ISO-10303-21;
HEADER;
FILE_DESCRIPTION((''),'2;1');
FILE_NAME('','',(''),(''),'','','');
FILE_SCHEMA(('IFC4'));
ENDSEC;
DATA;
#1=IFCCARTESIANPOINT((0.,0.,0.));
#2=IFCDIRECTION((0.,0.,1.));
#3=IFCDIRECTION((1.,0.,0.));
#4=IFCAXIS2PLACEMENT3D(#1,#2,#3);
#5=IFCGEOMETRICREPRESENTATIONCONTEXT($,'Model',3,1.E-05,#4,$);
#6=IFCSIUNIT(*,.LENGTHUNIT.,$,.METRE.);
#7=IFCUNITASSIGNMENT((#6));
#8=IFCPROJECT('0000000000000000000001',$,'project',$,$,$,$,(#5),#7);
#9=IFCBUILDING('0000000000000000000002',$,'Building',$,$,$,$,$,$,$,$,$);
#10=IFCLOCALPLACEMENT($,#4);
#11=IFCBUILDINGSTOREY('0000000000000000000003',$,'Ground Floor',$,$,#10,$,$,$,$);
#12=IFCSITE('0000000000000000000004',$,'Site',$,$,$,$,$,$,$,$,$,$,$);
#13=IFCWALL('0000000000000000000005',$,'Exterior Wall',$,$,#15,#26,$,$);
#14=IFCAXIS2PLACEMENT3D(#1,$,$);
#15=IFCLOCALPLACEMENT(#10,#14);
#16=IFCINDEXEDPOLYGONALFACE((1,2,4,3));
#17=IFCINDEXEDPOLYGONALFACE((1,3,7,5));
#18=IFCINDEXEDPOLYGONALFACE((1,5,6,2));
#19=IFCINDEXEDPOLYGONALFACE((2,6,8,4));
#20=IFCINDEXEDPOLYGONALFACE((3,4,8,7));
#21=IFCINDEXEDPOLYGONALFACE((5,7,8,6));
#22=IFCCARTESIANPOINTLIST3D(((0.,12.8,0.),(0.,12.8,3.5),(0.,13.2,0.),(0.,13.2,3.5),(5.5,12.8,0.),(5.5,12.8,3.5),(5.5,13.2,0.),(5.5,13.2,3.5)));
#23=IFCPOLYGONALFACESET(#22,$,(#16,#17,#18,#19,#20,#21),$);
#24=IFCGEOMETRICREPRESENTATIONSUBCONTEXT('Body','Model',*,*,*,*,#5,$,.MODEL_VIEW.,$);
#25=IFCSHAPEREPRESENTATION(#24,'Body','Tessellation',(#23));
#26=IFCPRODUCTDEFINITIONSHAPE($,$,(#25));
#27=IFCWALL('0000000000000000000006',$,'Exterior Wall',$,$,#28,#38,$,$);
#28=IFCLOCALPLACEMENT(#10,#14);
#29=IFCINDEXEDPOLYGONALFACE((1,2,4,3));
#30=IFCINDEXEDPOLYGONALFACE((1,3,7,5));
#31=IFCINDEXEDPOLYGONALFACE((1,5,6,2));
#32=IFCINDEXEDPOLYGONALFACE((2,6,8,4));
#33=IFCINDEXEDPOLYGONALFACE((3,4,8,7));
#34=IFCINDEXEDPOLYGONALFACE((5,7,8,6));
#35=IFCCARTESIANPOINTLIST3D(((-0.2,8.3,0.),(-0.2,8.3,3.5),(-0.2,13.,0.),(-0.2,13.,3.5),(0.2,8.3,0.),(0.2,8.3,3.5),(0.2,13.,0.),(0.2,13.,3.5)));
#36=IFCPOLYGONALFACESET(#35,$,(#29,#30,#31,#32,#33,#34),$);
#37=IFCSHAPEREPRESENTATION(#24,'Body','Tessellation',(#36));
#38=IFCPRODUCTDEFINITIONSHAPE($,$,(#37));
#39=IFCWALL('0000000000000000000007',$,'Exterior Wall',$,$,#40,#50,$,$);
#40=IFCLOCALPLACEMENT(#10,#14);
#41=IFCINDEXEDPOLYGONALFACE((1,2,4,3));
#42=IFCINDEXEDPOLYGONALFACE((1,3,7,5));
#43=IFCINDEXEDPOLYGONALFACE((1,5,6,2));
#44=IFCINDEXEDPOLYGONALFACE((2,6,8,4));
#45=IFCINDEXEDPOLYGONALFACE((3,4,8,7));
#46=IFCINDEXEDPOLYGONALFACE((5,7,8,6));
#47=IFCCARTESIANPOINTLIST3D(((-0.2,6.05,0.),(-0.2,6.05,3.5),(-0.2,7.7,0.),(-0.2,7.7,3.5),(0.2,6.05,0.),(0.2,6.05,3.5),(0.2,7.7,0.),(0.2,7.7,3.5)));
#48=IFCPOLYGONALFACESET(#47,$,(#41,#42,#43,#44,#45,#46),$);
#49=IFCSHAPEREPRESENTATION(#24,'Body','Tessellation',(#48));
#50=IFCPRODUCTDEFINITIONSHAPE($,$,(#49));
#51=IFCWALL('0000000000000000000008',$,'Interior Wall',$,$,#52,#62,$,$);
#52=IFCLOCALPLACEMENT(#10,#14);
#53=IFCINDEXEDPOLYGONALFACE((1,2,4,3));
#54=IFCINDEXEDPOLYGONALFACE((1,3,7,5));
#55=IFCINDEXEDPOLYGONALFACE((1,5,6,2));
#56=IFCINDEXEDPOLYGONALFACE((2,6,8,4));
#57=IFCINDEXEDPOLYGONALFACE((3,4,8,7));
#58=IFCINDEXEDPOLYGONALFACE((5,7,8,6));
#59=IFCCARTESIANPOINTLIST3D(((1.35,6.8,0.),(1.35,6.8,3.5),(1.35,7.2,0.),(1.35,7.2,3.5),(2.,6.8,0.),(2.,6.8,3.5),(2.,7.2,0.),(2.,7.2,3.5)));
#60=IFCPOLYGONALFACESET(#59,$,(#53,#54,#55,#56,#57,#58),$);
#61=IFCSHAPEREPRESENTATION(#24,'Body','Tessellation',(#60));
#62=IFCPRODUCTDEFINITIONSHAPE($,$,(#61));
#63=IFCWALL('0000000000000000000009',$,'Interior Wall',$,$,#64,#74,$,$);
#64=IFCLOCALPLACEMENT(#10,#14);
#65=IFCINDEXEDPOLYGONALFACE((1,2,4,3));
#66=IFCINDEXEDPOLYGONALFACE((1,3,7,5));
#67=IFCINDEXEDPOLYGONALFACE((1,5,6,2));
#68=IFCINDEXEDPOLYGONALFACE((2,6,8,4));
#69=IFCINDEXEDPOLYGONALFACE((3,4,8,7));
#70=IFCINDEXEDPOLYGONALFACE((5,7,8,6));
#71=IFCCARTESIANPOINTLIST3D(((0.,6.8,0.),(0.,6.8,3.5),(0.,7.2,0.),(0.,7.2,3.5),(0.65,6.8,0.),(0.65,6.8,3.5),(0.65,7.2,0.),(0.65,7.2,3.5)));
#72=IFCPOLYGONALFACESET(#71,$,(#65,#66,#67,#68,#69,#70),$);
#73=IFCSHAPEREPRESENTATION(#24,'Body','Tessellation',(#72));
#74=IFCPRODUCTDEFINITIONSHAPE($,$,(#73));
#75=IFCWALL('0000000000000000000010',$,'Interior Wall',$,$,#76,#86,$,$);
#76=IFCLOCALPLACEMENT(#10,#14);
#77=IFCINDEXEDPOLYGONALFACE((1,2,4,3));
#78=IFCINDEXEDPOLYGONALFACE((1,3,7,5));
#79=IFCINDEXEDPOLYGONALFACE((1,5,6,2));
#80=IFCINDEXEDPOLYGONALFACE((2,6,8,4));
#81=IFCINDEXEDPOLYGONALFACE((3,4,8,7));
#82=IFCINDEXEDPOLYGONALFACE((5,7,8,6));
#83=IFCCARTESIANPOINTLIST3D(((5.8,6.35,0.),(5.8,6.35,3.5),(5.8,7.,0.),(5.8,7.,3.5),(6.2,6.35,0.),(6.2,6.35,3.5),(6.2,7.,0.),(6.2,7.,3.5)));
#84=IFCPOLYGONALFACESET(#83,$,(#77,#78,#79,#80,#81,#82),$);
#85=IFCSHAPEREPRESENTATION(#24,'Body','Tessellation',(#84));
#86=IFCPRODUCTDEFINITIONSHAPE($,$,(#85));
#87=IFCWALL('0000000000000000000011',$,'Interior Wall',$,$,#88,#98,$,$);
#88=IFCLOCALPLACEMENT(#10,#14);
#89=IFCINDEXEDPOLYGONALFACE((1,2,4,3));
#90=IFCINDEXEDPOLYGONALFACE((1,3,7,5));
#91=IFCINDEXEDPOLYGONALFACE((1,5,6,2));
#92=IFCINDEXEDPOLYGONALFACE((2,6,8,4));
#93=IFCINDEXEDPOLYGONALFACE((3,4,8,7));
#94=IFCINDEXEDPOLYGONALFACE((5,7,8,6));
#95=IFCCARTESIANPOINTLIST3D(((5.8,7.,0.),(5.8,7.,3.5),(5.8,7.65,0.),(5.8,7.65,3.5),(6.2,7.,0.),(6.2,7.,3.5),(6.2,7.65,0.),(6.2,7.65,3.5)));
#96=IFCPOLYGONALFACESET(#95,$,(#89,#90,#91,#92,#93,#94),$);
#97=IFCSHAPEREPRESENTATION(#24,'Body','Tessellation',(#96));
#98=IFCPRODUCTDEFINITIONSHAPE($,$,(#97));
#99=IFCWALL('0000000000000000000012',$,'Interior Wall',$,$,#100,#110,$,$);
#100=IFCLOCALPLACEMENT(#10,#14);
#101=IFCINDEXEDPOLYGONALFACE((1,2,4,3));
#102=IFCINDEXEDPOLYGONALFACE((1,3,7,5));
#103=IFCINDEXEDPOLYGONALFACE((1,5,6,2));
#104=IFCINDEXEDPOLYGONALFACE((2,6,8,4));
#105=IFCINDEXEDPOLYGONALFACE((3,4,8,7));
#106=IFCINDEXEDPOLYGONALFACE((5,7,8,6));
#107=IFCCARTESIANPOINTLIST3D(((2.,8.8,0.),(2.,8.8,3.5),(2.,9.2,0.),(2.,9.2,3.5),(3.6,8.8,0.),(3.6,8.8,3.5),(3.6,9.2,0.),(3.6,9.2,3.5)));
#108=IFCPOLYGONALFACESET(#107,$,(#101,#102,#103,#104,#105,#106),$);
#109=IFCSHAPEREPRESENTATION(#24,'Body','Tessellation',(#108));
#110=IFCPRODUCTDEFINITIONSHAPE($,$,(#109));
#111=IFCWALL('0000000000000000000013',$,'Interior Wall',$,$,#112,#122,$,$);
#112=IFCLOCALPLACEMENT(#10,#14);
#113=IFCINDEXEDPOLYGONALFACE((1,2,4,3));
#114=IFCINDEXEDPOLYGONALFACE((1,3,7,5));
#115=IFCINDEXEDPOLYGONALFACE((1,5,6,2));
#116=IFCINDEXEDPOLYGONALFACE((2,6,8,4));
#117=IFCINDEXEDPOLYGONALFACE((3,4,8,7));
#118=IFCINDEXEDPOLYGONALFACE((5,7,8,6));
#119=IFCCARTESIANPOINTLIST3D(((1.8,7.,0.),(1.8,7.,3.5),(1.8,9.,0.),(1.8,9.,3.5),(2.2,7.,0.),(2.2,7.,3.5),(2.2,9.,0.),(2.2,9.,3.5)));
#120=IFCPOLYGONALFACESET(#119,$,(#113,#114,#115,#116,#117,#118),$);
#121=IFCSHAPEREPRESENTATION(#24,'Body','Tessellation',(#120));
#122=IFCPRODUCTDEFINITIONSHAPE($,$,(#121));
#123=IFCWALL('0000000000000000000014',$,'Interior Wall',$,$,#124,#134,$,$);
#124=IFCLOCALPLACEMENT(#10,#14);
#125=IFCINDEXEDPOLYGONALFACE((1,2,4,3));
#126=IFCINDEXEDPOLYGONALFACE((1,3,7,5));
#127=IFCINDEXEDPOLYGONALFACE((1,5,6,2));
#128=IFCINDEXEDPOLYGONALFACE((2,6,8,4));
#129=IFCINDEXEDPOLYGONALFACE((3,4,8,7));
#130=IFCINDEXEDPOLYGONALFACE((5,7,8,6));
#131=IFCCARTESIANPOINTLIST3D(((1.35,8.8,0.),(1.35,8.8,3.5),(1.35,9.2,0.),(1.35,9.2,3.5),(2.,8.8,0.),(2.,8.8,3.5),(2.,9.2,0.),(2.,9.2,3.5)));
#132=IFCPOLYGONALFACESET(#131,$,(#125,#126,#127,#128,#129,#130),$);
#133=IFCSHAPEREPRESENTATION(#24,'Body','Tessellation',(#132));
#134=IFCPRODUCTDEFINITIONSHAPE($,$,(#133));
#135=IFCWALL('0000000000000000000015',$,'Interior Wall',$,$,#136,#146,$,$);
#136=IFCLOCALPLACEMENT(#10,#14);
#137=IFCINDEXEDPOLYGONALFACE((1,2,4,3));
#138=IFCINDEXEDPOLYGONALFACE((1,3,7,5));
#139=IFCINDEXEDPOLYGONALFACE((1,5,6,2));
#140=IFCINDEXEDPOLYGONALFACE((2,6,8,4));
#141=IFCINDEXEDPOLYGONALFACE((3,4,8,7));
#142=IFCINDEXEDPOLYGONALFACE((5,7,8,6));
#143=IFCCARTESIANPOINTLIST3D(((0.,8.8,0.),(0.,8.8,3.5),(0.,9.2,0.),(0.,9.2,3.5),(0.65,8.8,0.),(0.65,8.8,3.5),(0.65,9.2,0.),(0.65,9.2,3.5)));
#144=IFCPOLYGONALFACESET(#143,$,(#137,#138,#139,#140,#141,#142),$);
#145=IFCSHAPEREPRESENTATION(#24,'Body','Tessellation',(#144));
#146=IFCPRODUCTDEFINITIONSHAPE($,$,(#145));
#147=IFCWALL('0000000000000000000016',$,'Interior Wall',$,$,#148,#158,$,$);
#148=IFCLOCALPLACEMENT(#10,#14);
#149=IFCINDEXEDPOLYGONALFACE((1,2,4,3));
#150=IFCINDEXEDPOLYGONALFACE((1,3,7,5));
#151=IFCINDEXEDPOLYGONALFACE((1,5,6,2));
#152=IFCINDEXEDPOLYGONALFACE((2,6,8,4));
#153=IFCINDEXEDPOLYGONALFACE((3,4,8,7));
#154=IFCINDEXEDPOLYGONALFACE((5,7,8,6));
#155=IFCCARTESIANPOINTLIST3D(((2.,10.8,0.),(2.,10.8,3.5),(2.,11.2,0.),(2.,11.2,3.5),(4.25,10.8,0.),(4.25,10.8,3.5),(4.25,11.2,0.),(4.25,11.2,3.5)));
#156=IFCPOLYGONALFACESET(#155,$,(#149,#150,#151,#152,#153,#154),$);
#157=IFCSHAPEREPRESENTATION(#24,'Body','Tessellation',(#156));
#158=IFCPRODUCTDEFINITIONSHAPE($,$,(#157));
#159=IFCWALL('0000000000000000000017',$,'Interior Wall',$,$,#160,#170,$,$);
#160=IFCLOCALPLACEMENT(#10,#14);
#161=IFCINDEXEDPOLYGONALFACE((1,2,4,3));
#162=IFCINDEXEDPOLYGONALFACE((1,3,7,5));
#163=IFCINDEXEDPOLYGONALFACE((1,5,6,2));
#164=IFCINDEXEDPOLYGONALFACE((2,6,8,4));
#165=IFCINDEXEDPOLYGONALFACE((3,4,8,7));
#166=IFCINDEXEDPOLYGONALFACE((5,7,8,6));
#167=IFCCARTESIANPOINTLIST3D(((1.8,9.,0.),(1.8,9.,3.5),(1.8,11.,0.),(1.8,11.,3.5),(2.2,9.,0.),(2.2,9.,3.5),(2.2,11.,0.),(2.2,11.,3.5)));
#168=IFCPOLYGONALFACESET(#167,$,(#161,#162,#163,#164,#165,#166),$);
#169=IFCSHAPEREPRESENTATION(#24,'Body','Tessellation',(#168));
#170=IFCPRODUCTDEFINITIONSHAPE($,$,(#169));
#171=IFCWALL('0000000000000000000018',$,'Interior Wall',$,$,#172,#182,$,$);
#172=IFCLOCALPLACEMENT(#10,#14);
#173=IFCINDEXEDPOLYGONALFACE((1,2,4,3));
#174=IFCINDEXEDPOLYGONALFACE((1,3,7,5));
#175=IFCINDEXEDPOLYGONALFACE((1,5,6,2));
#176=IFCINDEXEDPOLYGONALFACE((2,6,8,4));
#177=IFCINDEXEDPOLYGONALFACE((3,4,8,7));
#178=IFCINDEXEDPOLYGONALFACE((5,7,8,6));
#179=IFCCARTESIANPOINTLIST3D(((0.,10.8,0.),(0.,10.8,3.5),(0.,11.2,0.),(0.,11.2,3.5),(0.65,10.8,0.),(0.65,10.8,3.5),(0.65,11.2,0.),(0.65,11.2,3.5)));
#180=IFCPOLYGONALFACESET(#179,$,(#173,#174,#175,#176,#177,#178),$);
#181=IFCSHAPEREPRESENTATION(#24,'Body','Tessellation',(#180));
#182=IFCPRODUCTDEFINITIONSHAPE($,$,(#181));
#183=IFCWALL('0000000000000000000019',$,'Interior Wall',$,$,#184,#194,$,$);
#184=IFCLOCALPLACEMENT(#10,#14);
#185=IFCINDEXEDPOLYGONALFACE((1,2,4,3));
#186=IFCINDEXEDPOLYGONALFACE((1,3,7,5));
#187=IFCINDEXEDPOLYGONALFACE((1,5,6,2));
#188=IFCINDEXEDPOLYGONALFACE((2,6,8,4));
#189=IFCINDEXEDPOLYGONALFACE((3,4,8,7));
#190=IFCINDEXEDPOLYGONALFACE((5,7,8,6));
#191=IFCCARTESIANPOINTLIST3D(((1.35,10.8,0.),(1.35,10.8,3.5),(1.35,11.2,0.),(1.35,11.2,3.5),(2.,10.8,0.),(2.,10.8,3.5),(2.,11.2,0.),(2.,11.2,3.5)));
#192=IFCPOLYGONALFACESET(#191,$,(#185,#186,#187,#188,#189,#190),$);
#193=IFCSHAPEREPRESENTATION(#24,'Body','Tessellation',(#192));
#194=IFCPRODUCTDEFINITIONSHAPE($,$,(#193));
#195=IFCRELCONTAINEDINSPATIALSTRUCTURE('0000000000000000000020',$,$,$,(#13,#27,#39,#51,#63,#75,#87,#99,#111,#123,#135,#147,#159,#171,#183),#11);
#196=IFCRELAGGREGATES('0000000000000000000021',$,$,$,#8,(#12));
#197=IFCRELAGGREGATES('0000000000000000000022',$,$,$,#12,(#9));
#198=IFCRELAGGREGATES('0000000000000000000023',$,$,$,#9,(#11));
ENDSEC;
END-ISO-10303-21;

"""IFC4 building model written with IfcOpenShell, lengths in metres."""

from ifc_helpers import new_model, si_unit, frame, origin_with_axes, place, context, subcontext, project, spatial, indexed_curve, outline, extrude, element, save


model = new_model("IFC4")

# Units and contexts
model_context = context("Model", 3, precision=1e-05, world=origin_with_axes())
body_context = subcontext(model_context, "Body", "Model", "MODEL_VIEW")
ifc_project = project(units=[si_unit("LENGTHUNIT", "METRE")], contexts=[model_context])

# Site, building, storey
site = spatial("IfcSite", under=ifc_project, Name="Site")
building = spatial("IfcBuilding", under=site, Name="Building")
storey_placement = place(None, origin_with_axes())
storey = spatial("IfcBuildingStorey", under=building, at=storey_placement, Name="Ground Floor")

# Walls
wall_1_placement = place(storey_placement, frame((5.5, 13.0, 0.0), z_axis=(0.0, 0.0, 1.0), x_axis=(-1.0, 0.0, 0.0)))
element("IfcWall", 1, at=wall_1_placement, inside=storey, Name="Exterior Wall", context=body_context, shape_type="SweptSolid", body=[
    extrude(outline(indexed_curve([(0.0, 0.0), (0.0, 0.4), (5.5, 0.4), (5.5, 0.0), (0.0, 0.0)], self_intersect=False)), frame((0.0, -0.2, 0.0), z_axis=(0.0, 0.0, 1.0), x_axis=(1.0, 0.0, 0.0)), (0.0, 0.0, 1.0), 3.5),
])
wall_2_placement = place(storey_placement, frame((0.0, 13.0, 0.0), z_axis=(0.0, 0.0, 1.0), x_axis=(0.0, -1.0, 0.0)))
element("IfcWall", 2, at=wall_2_placement, inside=storey, Name="Exterior Wall", context=body_context, shape_type="SweptSolid", body=[
    extrude(outline(indexed_curve([(0.0, 0.0), (0.0, 0.4), (4.7, 0.4), (4.7, 0.0), (0.0, 0.0)], self_intersect=False)), frame((0.0, -0.2, 0.0), z_axis=(0.0, 0.0, 1.0), x_axis=(1.0, 0.0, 0.0)), (0.0, 0.0, 1.0), 3.5),
])
wall_3_placement = place(storey_placement, frame((0.0, 7.7, 0.0), z_axis=(0.0, 0.0, 1.0), x_axis=(0.0, -1.0, 0.0)))
element("IfcWall", 3, at=wall_3_placement, inside=storey, Name="Exterior Wall", context=body_context, shape_type="SweptSolid", body=[
    extrude(outline(indexed_curve([(0.0, 0.0), (0.0, 0.4), (1.65, 0.4), (1.65, 0.0), (0.0, 0.0)], self_intersect=False)), frame((0.0, -0.2, 0.0), z_axis=(0.0, 0.0, 1.0), x_axis=(1.0, 0.0, 0.0)), (0.0, 0.0, 1.0), 3.5),
])
for number, where, z_axis, x_axis, name in (
    (4, (2.0, 7.0, 0.0), (0.0, 0.0, 1.0), (-1.0, 0.0, 0.0), "Interior Wall"),
    (5, (0.65, 7.0, 0.0), (0.0, 0.0, 1.0), (-1.0, 0.0, 0.0), "Interior Wall"),
):
    element("IfcWall", number, at=place(storey_placement, frame(where, z_axis=z_axis, x_axis=x_axis)), inside=storey, Name=name, context=body_context, shape_type="SweptSolid", body=[
        extrude(outline(indexed_curve([(0.0, 0.0), (0.0, 0.4), (0.65, 0.4), (0.65, 0.0), (0.0, 0.0)], self_intersect=False)), frame((0.0, -0.2, 0.0), z_axis=(0.0, 0.0, 1.0), x_axis=(1.0, 0.0, 0.0)), (0.0, 0.0, 1.0), 3.5),
    ])
for number, where, z_axis, x_axis, name in (
    (6, (6.0, 6.35, 0.0), (0.0, 0.0, 1.0), (0.0, 1.0, 0.0), "Interior Wall"),
    (7, (6.0, 7.0, 0.0), (0.0, 0.0, 1.0), (0.0, 1.0, 0.0), "Interior Wall"),
):
    element("IfcWall", number, at=place(storey_placement, frame(where, z_axis=z_axis, x_axis=x_axis)), inside=storey, Name=name, context=body_context, shape_type="SweptSolid", body=[
        extrude(outline(indexed_curve([(0.0, 0.0), (0.0, 0.4), (0.65, 0.4), (0.65, 0.0), (0.0, 0.0)], self_intersect=False)), frame((0.0, -0.2, 0.0), z_axis=(0.0, 0.0, 1.0), x_axis=(1.0, 0.0, 0.0)), (0.0, 0.0, 1.0), 3.5),
    ])
wall_4_placement = place(storey_placement, frame((3.6, 9.0, 0.0), z_axis=(0.0, 0.0, 1.0), x_axis=(-1.0, 0.0, 0.0)))
element("IfcWall", 8, at=wall_4_placement, inside=storey, Name="Interior Wall", context=body_context, shape_type="SweptSolid", body=[
    extrude(outline(indexed_curve([(0.0, 0.0), (0.0, 0.4), (1.6, 0.4), (1.6, 0.0), (0.0, 0.0)], self_intersect=False)), frame((0.0, -0.2, 0.0), z_axis=(0.0, 0.0, 1.0), x_axis=(1.0, 0.0, 0.0)), (0.0, 0.0, 1.0), 3.5),
])
wall_5_placement = place(storey_placement, frame((2.0, 9.0, 0.0), z_axis=(0.0, 0.0, 1.0), x_axis=(0.0, -1.0, 0.0)))
element("IfcWall", 9, at=wall_5_placement, inside=storey, Name="Interior Wall", context=body_context, shape_type="SweptSolid", body=[
    extrude(outline(indexed_curve([(0.0, 0.0), (0.0, 0.4), (2.0, 0.4), (2.0, 0.0), (0.0, 0.0)], self_intersect=False)), frame((0.0, -0.2, 0.0), z_axis=(0.0, 0.0, 1.0), x_axis=(1.0, 0.0, 0.0)), (0.0, 0.0, 1.0), 3.5),
])
for number, where, z_axis, x_axis, name in (
    (10, (2.0, 9.0, 0.0), (0.0, 0.0, 1.0), (-1.0, 0.0, 0.0), "Interior Wall"),
    (11, (0.65, 9.0, 0.0), (0.0, 0.0, 1.0), (-1.0, 0.0, 0.0), "Interior Wall"),
):
    element("IfcWall", number, at=place(storey_placement, frame(where, z_axis=z_axis, x_axis=x_axis)), inside=storey, Name=name, context=body_context, shape_type="SweptSolid", body=[
        extrude(outline(indexed_curve([(0.0, 0.0), (0.0, 0.4), (0.65, 0.4), (0.65, 0.0), (0.0, 0.0)], self_intersect=False)), frame((0.0, -0.2, 0.0), z_axis=(0.0, 0.0, 1.0), x_axis=(1.0, 0.0, 0.0)), (0.0, 0.0, 1.0), 3.5),
    ])
wall_6_placement = place(storey_placement, frame((4.25, 11.0, 0.0), z_axis=(0.0, 0.0, 1.0), x_axis=(-1.0, 0.0, 0.0)))
element("IfcWall", 12, at=wall_6_placement, inside=storey, Name="Interior Wall", context=body_context, shape_type="SweptSolid", body=[
    extrude(outline(indexed_curve([(0.0, 0.0), (0.0, 0.4), (2.25, 0.4), (2.25, 0.0), (0.0, 0.0)], self_intersect=False)), frame((0.0, -0.2, 0.0), z_axis=(0.0, 0.0, 1.0), x_axis=(1.0, 0.0, 0.0)), (0.0, 0.0, 1.0), 3.5),
])
wall_7_placement = place(storey_placement, frame((2.0, 11.0, 0.0), z_axis=(0.0, 0.0, 1.0), x_axis=(0.0, -1.0, 0.0)))
element("IfcWall", 13, at=wall_7_placement, inside=storey, Name="Interior Wall", context=body_context, shape_type="SweptSolid", body=[
    extrude(outline(indexed_curve([(0.0, 0.0), (0.0, 0.4), (2.0, 0.4), (2.0, 0.0), (0.0, 0.0)], self_intersect=False)), frame((0.0, -0.2, 0.0), z_axis=(0.0, 0.0, 1.0), x_axis=(1.0, 0.0, 0.0)), (0.0, 0.0, 1.0), 3.5),
])
wall_8_placement = place(storey_placement, frame((0.0, 11.0, 0.0), z_axis=(0.0, 0.0, 1.0), x_axis=(1.0, 0.0, 0.0)))
element("IfcWall", 14, at=wall_8_placement, inside=storey, Name="Interior Wall", context=body_context, shape_type="SweptSolid", body=[
    extrude(outline(indexed_curve([(0.0, 0.0), (0.0, 0.4), (0.65, 0.4), (0.65, 0.0), (0.0, 0.0)], self_intersect=False)), frame((0.0, -0.2, 0.0), z_axis=(0.0, 0.0, 1.0), x_axis=(1.0, 0.0, 0.0)), (0.0, 0.0, 1.0), 3.5),
])
wall_9_placement = place(storey_placement, frame((1.35, 11.0, 0.0), z_axis=(0.0, 0.0, 1.0), x_axis=(1.0, 0.0, 0.0)))
element("IfcWall", 15, at=wall_9_placement, inside=storey, Name="Interior Wall", context=body_context, shape_type="SweptSolid", body=[
    extrude(outline(indexed_curve([(0.0, 0.0), (0.0, 0.4), (0.65, 0.4), (0.65, 0.0), (0.0, 0.0)], self_intersect=False)), frame((0.0, -0.2, 0.0), z_axis=(0.0, 0.0, 1.0), x_axis=(1.0, 0.0, 0.0)), (0.0, 0.0, 1.0), 3.5),
])

save(model, "model.ifc")
